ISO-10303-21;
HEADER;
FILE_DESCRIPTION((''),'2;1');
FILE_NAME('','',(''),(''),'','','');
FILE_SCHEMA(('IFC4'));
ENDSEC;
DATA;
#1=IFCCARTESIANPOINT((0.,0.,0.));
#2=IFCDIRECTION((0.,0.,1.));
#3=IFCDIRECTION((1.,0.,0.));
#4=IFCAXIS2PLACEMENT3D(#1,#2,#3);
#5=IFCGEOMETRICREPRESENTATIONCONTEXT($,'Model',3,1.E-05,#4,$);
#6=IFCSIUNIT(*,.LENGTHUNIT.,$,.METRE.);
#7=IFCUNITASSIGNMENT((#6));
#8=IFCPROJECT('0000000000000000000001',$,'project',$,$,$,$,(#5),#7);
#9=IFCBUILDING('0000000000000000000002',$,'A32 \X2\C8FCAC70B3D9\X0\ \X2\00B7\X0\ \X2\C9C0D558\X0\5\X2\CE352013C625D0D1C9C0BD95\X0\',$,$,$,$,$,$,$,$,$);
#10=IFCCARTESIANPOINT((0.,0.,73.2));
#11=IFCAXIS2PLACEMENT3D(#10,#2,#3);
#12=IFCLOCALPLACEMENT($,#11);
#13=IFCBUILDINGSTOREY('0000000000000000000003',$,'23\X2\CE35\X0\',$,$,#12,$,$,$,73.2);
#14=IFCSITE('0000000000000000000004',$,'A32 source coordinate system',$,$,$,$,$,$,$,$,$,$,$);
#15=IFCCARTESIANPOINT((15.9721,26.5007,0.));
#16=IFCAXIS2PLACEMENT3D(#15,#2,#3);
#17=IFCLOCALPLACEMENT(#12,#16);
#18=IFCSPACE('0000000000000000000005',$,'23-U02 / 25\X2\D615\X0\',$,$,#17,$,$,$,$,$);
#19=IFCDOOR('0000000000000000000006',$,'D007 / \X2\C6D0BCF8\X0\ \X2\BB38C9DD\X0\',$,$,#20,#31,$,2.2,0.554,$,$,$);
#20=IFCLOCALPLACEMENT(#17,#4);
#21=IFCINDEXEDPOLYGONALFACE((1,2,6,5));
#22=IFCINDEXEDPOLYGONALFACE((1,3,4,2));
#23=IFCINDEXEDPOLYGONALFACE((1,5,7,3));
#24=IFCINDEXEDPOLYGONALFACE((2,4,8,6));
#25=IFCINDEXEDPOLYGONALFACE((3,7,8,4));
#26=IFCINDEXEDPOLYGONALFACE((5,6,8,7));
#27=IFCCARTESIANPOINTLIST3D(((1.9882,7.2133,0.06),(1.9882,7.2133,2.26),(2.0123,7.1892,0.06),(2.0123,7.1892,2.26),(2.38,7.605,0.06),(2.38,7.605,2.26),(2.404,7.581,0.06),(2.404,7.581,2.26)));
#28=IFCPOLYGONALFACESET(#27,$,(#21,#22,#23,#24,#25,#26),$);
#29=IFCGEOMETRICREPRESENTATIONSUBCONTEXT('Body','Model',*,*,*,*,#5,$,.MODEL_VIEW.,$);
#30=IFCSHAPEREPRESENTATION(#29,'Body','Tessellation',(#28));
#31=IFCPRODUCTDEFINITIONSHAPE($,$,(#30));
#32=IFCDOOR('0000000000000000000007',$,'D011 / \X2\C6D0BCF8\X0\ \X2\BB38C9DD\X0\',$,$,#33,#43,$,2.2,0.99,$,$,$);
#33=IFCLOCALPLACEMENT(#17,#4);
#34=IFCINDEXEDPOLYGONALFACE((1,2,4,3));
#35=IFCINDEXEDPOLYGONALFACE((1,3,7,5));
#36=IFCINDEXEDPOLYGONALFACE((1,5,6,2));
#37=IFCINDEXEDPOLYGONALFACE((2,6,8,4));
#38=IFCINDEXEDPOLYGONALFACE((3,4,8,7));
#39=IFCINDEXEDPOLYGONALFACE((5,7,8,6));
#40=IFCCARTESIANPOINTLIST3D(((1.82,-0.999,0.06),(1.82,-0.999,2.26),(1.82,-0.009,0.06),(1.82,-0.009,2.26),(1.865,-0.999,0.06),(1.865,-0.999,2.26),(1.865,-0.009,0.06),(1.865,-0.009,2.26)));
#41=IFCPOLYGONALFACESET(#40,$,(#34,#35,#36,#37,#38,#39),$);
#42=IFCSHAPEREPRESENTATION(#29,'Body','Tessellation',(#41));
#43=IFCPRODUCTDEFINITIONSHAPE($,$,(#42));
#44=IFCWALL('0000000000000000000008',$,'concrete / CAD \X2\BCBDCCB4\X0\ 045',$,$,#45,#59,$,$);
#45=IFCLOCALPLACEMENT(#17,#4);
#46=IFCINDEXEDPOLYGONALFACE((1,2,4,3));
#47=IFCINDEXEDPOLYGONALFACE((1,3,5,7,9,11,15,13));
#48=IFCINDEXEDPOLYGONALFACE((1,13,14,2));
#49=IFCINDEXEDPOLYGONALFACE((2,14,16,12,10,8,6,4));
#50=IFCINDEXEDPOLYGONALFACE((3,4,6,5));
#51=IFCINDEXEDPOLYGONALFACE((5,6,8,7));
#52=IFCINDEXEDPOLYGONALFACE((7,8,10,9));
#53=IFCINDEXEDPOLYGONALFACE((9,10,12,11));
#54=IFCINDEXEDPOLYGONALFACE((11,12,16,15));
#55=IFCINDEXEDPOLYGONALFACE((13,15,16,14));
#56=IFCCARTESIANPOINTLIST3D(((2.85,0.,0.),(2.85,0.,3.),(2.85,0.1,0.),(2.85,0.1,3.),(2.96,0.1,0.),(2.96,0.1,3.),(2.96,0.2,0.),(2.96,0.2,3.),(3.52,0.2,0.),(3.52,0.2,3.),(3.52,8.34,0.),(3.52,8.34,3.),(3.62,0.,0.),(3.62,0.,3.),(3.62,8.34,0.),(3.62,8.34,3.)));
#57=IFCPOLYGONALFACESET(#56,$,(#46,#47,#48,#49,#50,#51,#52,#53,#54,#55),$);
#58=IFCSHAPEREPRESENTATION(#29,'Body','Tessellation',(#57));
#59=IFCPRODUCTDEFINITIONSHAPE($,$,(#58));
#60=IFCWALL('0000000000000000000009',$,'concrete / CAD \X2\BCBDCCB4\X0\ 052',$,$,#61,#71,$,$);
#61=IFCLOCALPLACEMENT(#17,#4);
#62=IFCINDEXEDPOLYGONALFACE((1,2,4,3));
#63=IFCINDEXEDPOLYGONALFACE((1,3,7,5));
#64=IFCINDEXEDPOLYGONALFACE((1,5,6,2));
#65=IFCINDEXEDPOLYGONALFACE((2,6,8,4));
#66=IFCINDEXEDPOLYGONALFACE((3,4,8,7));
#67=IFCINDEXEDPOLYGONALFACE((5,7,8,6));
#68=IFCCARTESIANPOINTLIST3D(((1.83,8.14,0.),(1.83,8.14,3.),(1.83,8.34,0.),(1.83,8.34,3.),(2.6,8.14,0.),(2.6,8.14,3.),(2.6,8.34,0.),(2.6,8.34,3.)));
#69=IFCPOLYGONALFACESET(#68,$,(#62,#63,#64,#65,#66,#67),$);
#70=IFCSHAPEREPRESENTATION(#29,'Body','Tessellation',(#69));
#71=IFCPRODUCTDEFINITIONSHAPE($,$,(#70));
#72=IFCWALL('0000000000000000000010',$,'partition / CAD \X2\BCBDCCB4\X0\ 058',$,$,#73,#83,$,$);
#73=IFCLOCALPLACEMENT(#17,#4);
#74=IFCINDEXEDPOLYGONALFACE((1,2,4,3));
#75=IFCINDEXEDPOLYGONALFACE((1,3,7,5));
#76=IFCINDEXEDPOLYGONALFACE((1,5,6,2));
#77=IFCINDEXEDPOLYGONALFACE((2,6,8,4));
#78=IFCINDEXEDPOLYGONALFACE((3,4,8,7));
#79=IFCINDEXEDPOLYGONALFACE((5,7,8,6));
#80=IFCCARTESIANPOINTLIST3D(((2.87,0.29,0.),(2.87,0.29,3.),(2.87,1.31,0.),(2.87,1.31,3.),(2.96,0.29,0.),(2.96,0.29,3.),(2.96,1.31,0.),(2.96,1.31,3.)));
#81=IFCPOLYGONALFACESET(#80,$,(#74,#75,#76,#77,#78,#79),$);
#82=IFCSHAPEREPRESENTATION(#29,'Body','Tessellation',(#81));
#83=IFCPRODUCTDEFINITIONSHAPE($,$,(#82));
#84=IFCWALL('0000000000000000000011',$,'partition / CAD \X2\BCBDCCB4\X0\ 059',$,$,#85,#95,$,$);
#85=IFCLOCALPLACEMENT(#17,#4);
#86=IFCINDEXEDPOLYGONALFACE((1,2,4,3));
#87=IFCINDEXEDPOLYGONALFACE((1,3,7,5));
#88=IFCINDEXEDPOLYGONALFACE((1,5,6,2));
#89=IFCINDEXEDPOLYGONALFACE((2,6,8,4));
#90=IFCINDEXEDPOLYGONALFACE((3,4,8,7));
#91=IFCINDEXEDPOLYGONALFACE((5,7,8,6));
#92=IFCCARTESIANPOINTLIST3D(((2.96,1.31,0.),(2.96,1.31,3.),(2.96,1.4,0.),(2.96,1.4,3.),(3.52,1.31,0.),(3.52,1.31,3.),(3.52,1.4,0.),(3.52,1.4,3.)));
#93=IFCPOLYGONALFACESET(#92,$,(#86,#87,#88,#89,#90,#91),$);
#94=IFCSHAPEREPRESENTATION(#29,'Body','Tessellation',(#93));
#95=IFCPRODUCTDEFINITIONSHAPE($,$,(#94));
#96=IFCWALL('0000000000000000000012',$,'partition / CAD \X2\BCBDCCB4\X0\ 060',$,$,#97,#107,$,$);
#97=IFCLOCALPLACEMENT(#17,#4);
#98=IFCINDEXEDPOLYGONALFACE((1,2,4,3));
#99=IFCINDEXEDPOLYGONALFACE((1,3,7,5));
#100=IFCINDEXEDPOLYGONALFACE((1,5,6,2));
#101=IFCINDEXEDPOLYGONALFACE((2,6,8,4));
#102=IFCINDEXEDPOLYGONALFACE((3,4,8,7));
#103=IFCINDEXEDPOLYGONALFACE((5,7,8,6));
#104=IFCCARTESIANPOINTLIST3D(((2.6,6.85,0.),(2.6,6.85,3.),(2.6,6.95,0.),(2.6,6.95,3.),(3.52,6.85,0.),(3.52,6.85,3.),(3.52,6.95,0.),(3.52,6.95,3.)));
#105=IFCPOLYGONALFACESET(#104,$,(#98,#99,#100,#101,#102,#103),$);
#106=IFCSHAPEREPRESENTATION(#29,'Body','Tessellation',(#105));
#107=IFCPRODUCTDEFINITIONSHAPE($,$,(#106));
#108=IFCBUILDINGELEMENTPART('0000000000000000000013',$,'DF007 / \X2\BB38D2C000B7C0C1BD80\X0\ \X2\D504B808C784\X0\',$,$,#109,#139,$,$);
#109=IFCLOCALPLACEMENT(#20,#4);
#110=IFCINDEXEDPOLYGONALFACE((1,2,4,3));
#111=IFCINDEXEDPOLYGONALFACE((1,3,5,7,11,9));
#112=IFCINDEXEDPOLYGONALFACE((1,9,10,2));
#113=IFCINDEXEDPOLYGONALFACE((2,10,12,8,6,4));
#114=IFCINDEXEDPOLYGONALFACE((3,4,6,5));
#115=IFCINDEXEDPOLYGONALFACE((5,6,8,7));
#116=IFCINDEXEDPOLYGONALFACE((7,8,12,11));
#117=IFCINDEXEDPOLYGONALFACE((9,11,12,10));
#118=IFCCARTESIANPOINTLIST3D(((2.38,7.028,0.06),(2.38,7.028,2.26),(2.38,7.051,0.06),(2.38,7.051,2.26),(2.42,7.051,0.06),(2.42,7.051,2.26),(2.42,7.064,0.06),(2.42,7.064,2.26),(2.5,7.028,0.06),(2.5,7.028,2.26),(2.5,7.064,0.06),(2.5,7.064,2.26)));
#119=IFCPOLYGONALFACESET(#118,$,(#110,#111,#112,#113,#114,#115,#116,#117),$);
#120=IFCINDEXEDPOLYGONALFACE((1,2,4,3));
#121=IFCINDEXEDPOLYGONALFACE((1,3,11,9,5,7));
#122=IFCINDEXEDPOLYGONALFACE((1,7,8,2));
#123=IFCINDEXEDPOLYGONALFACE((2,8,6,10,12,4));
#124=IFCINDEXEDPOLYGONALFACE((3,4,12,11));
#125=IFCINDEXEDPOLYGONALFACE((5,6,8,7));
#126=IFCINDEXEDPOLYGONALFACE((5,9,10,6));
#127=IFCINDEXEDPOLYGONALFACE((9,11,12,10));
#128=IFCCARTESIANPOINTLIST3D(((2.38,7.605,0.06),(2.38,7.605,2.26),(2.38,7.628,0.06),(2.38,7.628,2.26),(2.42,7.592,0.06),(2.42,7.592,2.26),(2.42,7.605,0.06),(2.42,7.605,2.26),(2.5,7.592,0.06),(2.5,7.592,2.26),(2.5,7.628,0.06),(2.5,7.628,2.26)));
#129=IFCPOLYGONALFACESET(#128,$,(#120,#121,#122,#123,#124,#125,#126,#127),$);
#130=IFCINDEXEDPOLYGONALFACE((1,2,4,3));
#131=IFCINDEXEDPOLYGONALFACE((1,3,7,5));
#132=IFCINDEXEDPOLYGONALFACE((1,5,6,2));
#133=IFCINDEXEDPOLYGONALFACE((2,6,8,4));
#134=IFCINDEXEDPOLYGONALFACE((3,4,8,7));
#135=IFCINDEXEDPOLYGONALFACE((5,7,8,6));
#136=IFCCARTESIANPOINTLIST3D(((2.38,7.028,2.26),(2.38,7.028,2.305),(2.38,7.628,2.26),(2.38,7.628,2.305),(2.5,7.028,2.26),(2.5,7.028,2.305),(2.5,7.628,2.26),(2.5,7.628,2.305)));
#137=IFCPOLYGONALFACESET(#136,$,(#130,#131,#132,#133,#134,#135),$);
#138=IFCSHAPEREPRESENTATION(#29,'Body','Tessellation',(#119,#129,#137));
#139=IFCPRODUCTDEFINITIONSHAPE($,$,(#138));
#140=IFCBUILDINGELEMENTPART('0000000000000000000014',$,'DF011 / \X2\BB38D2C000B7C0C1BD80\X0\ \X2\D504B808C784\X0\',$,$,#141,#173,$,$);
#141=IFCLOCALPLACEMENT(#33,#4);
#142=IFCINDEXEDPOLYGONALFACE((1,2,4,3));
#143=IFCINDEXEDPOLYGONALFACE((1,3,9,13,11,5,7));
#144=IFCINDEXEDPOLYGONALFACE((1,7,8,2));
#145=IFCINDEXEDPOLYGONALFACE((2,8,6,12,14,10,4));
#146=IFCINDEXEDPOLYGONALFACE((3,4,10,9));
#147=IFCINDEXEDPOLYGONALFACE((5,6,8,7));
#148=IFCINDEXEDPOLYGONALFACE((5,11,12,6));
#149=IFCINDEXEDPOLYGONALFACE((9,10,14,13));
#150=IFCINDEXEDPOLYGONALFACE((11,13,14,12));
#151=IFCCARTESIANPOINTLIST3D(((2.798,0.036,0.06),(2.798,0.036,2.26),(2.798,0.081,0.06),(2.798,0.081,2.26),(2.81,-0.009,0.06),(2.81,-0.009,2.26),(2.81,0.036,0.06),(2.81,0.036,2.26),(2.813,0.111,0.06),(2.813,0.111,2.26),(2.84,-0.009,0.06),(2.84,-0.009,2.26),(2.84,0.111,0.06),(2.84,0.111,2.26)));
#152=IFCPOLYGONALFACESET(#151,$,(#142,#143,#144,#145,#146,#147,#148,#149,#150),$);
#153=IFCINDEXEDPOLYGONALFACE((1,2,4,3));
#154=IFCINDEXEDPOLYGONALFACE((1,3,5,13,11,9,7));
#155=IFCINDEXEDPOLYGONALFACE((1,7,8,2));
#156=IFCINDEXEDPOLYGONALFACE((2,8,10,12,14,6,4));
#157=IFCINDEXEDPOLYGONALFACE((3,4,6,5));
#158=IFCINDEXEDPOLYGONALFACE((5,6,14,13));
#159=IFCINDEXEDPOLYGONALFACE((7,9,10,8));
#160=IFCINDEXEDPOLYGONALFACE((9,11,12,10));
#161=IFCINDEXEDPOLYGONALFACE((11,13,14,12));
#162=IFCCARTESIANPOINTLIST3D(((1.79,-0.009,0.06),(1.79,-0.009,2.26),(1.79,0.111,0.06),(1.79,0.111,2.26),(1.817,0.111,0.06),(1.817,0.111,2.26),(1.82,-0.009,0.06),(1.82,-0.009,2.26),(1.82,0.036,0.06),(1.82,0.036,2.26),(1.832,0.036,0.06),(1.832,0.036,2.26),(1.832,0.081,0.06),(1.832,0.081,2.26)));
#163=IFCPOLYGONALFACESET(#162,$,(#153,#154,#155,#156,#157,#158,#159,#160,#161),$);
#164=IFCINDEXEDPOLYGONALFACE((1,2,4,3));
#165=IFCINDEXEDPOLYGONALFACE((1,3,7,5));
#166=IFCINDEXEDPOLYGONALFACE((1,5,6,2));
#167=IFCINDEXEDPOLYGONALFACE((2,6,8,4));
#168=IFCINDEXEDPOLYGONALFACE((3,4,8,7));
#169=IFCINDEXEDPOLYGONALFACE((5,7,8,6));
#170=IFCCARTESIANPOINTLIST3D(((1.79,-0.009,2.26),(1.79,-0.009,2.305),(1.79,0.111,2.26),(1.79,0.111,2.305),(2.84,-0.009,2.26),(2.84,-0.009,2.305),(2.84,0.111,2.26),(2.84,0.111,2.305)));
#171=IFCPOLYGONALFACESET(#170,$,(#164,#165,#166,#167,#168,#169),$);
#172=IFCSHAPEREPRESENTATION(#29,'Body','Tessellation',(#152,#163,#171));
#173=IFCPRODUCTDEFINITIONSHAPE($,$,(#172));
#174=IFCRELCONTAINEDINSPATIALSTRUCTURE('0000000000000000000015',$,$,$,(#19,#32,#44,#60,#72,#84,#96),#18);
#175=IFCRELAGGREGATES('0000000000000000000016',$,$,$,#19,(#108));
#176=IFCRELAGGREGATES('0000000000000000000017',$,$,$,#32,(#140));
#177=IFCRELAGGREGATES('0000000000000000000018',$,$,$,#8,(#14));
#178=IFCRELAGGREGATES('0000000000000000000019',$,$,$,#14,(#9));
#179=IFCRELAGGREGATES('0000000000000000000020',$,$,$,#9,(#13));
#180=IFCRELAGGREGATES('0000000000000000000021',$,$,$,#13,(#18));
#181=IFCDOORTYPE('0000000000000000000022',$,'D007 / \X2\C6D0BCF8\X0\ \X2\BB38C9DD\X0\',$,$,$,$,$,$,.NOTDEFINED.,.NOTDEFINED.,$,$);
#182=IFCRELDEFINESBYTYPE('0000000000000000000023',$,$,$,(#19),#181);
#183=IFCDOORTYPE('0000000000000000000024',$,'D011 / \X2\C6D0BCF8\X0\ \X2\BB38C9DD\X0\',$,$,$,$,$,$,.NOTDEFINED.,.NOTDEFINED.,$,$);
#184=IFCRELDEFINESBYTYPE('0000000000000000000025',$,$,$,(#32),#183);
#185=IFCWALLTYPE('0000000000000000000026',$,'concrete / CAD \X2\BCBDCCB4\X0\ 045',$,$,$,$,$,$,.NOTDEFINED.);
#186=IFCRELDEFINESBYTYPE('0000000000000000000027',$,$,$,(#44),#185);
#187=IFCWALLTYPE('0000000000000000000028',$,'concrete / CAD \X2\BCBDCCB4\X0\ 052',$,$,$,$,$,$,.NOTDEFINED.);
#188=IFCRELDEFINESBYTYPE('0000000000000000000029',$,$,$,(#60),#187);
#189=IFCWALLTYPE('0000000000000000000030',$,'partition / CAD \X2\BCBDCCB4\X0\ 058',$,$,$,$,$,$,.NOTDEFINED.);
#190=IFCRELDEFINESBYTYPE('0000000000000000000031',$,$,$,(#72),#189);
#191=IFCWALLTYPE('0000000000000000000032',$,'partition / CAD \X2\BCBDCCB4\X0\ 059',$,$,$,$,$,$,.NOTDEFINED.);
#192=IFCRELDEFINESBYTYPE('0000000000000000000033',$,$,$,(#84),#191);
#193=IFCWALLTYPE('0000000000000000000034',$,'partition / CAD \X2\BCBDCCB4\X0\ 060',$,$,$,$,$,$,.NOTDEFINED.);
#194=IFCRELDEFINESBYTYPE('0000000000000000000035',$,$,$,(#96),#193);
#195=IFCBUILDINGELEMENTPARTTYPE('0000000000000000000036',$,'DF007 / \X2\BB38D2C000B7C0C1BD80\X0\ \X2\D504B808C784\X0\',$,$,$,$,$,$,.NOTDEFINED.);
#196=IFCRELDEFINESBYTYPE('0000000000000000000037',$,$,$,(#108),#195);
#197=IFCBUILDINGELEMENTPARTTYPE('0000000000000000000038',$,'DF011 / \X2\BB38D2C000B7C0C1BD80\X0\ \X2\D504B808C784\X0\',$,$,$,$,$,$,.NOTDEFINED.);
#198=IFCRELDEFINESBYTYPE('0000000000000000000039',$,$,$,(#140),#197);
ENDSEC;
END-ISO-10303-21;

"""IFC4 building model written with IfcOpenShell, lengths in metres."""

from ifc_helpers import new_model, si_unit, frame, origin, origin_with_axes, place, context, subcontext, project, spatial, polyline, outline, extrude, source, transform, mapped, type_object, type_shapes, element, aggregate, save


model = new_model("IFC4")

# Units and contexts
model_context = context("Model", 3, precision=1e-05, world=origin_with_axes())
body_context = subcontext(model_context, "Body", "Model", "MODEL_VIEW")
ifc_project = project(units=[si_unit("LENGTHUNIT", "METRE")], contexts=[model_context])

# Site, building, storey, space
storey_placement = place(None, frame((0.0, 0.0, 73.2), z_axis=(0.0, 0.0, 1.0), x_axis=(1.0, 0.0, 0.0)))
space_placement = place(storey_placement, frame((15.9721, 26.5007, 0.0), z_axis=(0.0, 0.0, 1.0), x_axis=(1.0, 0.0, 0.0)))
site = spatial("IfcSite", under=ifc_project, Name="A32 source coordinate system")
building = spatial("IfcBuilding", under=site, Name="A32 주거동 · 지하5층–옥탑지붕")
storey = spatial("IfcBuildingStorey", under=building, at=storey_placement, Name="23층", Elevation=73.2)
space = spatial("IfcSpace", under=storey, at=space_placement, Name="23-U02 / 25형")

# Doors
door_type_1 = type_object("IfcDoorType", Name="D007 / 원본 문짝", OperationType="NOTDEFINED", PredefinedType="NOTDEFINED")
shared_shape_1 = source(origin(), body_context, "Body", "SweptSolid", [
    extrude(outline(polyline([(2.0123, 7.1892), (1.9882, 7.2133), (2.38, 7.605), (2.404, 7.581), (2.0123, 7.1892)])), frame((0.0, 0.0, 0.06)), (0.0, 0.0, 1.0), 2.2),
])
type_shapes(door_type_1, [shared_shape_1])
door_1_placement = place(space_placement, origin_with_axes())
door_1 = element("IfcDoor", 1, at=door_1_placement, inside=space, type_object=door_type_1, Name="D007 / 원본 문짝", OverallHeight=2.2, OverallWidth=0.554, context=body_context, shape_type="MappedRepresentation", body=[
    mapped(shared_shape_1, transform((0.0, 0.0, 0.0), scale=1.0)),
])
door_type_2 = type_object("IfcDoorType", Name="D011 / 원본 문짝", OperationType="NOTDEFINED", PredefinedType="NOTDEFINED")
shared_shape_2 = source(origin(), body_context, "Body", "SweptSolid", [
    extrude(outline(polyline([(1.865, -0.999), (1.82, -0.999), (1.82, -0.009), (1.865, -0.009), (1.865, -0.999)])), frame((0.0, 0.0, 0.06)), (0.0, 0.0, 1.0), 2.2),
])
type_shapes(door_type_2, [shared_shape_2])
door_2_placement = place(space_placement, origin_with_axes())
door_2 = element("IfcDoor", 2, at=door_2_placement, inside=space, type_object=door_type_2, Name="D011 / 원본 문짝", OverallHeight=2.2, OverallWidth=0.99, context=body_context, shape_type="MappedRepresentation", body=[
    mapped(shared_shape_2, transform((0.0, 0.0, 0.0), scale=1.0)),
])

# Walls
wall_type_1 = type_object("IfcWallType", Name="concrete / CAD 벽체 045", PredefinedType="NOTDEFINED")
shared_shape_3 = source(origin(), body_context, "Body", "SweptSolid", [
    extrude(outline(polyline([(2.96, 0.1), (2.96, 0.2), (3.52, 0.2), (3.52, 8.34), (3.72, 8.34), (3.72, 8.34), (3.62, 8.34), (3.62, 0.0), (2.85, 0.0), (2.85, 0.1), (2.96, 0.1)])), origin(), (0.0, 0.0, 1.0), 3.0),
])
type_shapes(wall_type_1, [shared_shape_3])
wall_1_placement = place(space_placement, origin_with_axes())
element("IfcWall", 3, at=wall_1_placement, inside=space, type_object=wall_type_1, Name="concrete / CAD 벽체 045", context=body_context, shape_type="MappedRepresentation", body=[
    mapped(shared_shape_3, transform((0.0, 0.0, 0.0), scale=1.0)),
])
wall_type_2 = type_object("IfcWallType", Name="concrete / CAD 벽체 052", PredefinedType="NOTDEFINED")
shared_shape_4 = source(origin(), body_context, "Body", "SweptSolid", [
    extrude(outline(polyline([(2.6, 8.14), (1.83, 8.14), (1.83, 8.34), (2.6, 8.34), (2.6, 8.14)])), origin(), (0.0, 0.0, 1.0), 3.0),
])
type_shapes(wall_type_2, [shared_shape_4])
wall_2_placement = place(space_placement, origin_with_axes())
element("IfcWall", 4, at=wall_2_placement, inside=space, type_object=wall_type_2, Name="concrete / CAD 벽체 052", context=body_context, shape_type="MappedRepresentation", body=[
    mapped(shared_shape_4, transform((0.0, 0.0, 0.0), scale=1.0)),
])
wall_type_3 = type_object("IfcWallType", Name="partition / CAD 벽체 058", PredefinedType="NOTDEFINED")
shared_shape_5 = source(origin(), body_context, "Body", "SweptSolid", [
    extrude(outline(polyline([(2.96, 1.31), (2.96, 0.29), (2.87, 0.29), (2.87, 1.31), (2.96, 1.31)])), origin(), (0.0, 0.0, 1.0), 3.0),
])
type_shapes(wall_type_3, [shared_shape_5])
wall_3_placement = place(space_placement, origin_with_axes())
element("IfcWall", 5, at=wall_3_placement, inside=space, type_object=wall_type_3, Name="partition / CAD 벽체 058", context=body_context, shape_type="MappedRepresentation", body=[
    mapped(shared_shape_5, transform((0.0, 0.0, 0.0), scale=1.0)),
])
wall_type_4 = type_object("IfcWallType", Name="partition / CAD 벽체 059", PredefinedType="NOTDEFINED")
shared_shape_6 = source(origin(), body_context, "Body", "SweptSolid", [
    extrude(outline(polyline([(3.52, 1.31), (2.96, 1.31), (2.96, 1.4), (3.52, 1.4), (3.52, 1.31)])), origin(), (0.0, 0.0, 1.0), 3.0),
])
type_shapes(wall_type_4, [shared_shape_6])
wall_4_placement = place(space_placement, origin_with_axes())
element("IfcWall", 6, at=wall_4_placement, inside=space, type_object=wall_type_4, Name="partition / CAD 벽체 059", context=body_context, shape_type="MappedRepresentation", body=[
    mapped(shared_shape_6, transform((0.0, 0.0, 0.0), scale=1.0)),
])
wall_type_5 = type_object("IfcWallType", Name="partition / CAD 벽체 060", PredefinedType="NOTDEFINED")
shared_shape_7 = source(origin(), body_context, "Body", "SweptSolid", [
    extrude(outline(polyline([(3.52, 6.85), (2.6, 6.85), (2.6, 6.95), (3.52, 6.95), (3.52, 6.85)])), origin(), (0.0, 0.0, 1.0), 3.0),
])
type_shapes(wall_type_5, [shared_shape_7])
wall_5_placement = place(space_placement, origin_with_axes())
element("IfcWall", 7, at=wall_5_placement, inside=space, type_object=wall_type_5, Name="partition / CAD 벽체 060", context=body_context, shape_type="MappedRepresentation", body=[
    mapped(shared_shape_7, transform((0.0, 0.0, 0.0), scale=1.0)),
])

# Building element parts
building_element_part_type_1 = type_object("IfcBuildingElementPartType", Name="DF007 / 문틀·상부 프레임", PredefinedType="NOTDEFINED")
shared_shape_8 = source(origin(), body_context, "Body", "SweptSolid", [
    extrude(outline(polyline([(2.38, 7.028), (2.38, 7.051), (2.42, 7.051), (2.42, 7.064), (2.5, 7.064), (2.5, 7.028), (2.38, 7.028)])), frame((0.0, 0.0, 0.06)), (0.0, 0.0, 1.0), 2.2),
    extrude(outline(polyline([(2.5, 7.592), (2.42, 7.592), (2.42, 7.605), (2.38, 7.605), (2.38, 7.628), (2.5, 7.628), (2.5, 7.592)])), frame((0.0, 0.0, 0.06)), (0.0, 0.0, 1.0), 2.2),
    extrude(outline(polyline([(2.38, 7.028), (2.38, 7.628), (2.5, 7.628), (2.5, 7.028), (2.38, 7.028)])), frame((0.0, 0.0, 2.26)), (0.0, 0.0, 1.0), 0.045),
])
type_shapes(building_element_part_type_1, [shared_shape_8])
building_element_part_1_placement = place(door_1_placement, origin_with_axes())
building_element_part_1 = element("IfcBuildingElementPart", 8, at=building_element_part_1_placement, type_object=building_element_part_type_1, Name="DF007 / 문틀·상부 프레임", context=body_context, shape_type="MappedRepresentation", body=[
    mapped(shared_shape_8, transform((0.0, 0.0, 0.0), scale=1.0)),
])
aggregate(door_1, [building_element_part_1])
building_element_part_type_2 = type_object("IfcBuildingElementPartType", Name="DF011 / 문틀·상부 프레임", PredefinedType="NOTDEFINED")
shared_shape_9 = source(origin(), body_context, "Body", "SweptSolid", [
    extrude(outline(polyline([(2.81, -0.009), (2.81, 0.036), (2.798, 0.036), (2.798, 0.081), (2.813, 0.111), (2.84, 0.111), (2.84, -0.009), (2.81, -0.009)])), frame((0.0, 0.0, 0.06)), (0.0, 0.0, 1.0), 2.2),
    extrude(outline(polyline([(1.79, 0.111), (1.817, 0.111), (1.832, 0.081), (1.832, 0.036), (1.82, 0.036), (1.82, -0.009), (1.79, -0.009), (1.79, 0.111)])), frame((0.0, 0.0, 0.06)), (0.0, 0.0, 1.0), 2.2),
    extrude(outline(polyline([(1.79, -0.009), (1.79, 0.111), (2.84, 0.111), (2.84, -0.009), (1.79, -0.009)])), frame((0.0, 0.0, 2.26)), (0.0, 0.0, 1.0), 0.045),
])
type_shapes(building_element_part_type_2, [shared_shape_9])
building_element_part_2_placement = place(door_2_placement, origin_with_axes())
building_element_part_2 = element("IfcBuildingElementPart", 9, at=building_element_part_2_placement, type_object=building_element_part_type_2, Name="DF011 / 문틀·상부 프레임", context=body_context, shape_type="MappedRepresentation", body=[
    mapped(shared_shape_9, transform((0.0, 0.0, 0.0), scale=1.0)),
])
aggregate(door_2, [building_element_part_2])

save(model, "model.ifc")
